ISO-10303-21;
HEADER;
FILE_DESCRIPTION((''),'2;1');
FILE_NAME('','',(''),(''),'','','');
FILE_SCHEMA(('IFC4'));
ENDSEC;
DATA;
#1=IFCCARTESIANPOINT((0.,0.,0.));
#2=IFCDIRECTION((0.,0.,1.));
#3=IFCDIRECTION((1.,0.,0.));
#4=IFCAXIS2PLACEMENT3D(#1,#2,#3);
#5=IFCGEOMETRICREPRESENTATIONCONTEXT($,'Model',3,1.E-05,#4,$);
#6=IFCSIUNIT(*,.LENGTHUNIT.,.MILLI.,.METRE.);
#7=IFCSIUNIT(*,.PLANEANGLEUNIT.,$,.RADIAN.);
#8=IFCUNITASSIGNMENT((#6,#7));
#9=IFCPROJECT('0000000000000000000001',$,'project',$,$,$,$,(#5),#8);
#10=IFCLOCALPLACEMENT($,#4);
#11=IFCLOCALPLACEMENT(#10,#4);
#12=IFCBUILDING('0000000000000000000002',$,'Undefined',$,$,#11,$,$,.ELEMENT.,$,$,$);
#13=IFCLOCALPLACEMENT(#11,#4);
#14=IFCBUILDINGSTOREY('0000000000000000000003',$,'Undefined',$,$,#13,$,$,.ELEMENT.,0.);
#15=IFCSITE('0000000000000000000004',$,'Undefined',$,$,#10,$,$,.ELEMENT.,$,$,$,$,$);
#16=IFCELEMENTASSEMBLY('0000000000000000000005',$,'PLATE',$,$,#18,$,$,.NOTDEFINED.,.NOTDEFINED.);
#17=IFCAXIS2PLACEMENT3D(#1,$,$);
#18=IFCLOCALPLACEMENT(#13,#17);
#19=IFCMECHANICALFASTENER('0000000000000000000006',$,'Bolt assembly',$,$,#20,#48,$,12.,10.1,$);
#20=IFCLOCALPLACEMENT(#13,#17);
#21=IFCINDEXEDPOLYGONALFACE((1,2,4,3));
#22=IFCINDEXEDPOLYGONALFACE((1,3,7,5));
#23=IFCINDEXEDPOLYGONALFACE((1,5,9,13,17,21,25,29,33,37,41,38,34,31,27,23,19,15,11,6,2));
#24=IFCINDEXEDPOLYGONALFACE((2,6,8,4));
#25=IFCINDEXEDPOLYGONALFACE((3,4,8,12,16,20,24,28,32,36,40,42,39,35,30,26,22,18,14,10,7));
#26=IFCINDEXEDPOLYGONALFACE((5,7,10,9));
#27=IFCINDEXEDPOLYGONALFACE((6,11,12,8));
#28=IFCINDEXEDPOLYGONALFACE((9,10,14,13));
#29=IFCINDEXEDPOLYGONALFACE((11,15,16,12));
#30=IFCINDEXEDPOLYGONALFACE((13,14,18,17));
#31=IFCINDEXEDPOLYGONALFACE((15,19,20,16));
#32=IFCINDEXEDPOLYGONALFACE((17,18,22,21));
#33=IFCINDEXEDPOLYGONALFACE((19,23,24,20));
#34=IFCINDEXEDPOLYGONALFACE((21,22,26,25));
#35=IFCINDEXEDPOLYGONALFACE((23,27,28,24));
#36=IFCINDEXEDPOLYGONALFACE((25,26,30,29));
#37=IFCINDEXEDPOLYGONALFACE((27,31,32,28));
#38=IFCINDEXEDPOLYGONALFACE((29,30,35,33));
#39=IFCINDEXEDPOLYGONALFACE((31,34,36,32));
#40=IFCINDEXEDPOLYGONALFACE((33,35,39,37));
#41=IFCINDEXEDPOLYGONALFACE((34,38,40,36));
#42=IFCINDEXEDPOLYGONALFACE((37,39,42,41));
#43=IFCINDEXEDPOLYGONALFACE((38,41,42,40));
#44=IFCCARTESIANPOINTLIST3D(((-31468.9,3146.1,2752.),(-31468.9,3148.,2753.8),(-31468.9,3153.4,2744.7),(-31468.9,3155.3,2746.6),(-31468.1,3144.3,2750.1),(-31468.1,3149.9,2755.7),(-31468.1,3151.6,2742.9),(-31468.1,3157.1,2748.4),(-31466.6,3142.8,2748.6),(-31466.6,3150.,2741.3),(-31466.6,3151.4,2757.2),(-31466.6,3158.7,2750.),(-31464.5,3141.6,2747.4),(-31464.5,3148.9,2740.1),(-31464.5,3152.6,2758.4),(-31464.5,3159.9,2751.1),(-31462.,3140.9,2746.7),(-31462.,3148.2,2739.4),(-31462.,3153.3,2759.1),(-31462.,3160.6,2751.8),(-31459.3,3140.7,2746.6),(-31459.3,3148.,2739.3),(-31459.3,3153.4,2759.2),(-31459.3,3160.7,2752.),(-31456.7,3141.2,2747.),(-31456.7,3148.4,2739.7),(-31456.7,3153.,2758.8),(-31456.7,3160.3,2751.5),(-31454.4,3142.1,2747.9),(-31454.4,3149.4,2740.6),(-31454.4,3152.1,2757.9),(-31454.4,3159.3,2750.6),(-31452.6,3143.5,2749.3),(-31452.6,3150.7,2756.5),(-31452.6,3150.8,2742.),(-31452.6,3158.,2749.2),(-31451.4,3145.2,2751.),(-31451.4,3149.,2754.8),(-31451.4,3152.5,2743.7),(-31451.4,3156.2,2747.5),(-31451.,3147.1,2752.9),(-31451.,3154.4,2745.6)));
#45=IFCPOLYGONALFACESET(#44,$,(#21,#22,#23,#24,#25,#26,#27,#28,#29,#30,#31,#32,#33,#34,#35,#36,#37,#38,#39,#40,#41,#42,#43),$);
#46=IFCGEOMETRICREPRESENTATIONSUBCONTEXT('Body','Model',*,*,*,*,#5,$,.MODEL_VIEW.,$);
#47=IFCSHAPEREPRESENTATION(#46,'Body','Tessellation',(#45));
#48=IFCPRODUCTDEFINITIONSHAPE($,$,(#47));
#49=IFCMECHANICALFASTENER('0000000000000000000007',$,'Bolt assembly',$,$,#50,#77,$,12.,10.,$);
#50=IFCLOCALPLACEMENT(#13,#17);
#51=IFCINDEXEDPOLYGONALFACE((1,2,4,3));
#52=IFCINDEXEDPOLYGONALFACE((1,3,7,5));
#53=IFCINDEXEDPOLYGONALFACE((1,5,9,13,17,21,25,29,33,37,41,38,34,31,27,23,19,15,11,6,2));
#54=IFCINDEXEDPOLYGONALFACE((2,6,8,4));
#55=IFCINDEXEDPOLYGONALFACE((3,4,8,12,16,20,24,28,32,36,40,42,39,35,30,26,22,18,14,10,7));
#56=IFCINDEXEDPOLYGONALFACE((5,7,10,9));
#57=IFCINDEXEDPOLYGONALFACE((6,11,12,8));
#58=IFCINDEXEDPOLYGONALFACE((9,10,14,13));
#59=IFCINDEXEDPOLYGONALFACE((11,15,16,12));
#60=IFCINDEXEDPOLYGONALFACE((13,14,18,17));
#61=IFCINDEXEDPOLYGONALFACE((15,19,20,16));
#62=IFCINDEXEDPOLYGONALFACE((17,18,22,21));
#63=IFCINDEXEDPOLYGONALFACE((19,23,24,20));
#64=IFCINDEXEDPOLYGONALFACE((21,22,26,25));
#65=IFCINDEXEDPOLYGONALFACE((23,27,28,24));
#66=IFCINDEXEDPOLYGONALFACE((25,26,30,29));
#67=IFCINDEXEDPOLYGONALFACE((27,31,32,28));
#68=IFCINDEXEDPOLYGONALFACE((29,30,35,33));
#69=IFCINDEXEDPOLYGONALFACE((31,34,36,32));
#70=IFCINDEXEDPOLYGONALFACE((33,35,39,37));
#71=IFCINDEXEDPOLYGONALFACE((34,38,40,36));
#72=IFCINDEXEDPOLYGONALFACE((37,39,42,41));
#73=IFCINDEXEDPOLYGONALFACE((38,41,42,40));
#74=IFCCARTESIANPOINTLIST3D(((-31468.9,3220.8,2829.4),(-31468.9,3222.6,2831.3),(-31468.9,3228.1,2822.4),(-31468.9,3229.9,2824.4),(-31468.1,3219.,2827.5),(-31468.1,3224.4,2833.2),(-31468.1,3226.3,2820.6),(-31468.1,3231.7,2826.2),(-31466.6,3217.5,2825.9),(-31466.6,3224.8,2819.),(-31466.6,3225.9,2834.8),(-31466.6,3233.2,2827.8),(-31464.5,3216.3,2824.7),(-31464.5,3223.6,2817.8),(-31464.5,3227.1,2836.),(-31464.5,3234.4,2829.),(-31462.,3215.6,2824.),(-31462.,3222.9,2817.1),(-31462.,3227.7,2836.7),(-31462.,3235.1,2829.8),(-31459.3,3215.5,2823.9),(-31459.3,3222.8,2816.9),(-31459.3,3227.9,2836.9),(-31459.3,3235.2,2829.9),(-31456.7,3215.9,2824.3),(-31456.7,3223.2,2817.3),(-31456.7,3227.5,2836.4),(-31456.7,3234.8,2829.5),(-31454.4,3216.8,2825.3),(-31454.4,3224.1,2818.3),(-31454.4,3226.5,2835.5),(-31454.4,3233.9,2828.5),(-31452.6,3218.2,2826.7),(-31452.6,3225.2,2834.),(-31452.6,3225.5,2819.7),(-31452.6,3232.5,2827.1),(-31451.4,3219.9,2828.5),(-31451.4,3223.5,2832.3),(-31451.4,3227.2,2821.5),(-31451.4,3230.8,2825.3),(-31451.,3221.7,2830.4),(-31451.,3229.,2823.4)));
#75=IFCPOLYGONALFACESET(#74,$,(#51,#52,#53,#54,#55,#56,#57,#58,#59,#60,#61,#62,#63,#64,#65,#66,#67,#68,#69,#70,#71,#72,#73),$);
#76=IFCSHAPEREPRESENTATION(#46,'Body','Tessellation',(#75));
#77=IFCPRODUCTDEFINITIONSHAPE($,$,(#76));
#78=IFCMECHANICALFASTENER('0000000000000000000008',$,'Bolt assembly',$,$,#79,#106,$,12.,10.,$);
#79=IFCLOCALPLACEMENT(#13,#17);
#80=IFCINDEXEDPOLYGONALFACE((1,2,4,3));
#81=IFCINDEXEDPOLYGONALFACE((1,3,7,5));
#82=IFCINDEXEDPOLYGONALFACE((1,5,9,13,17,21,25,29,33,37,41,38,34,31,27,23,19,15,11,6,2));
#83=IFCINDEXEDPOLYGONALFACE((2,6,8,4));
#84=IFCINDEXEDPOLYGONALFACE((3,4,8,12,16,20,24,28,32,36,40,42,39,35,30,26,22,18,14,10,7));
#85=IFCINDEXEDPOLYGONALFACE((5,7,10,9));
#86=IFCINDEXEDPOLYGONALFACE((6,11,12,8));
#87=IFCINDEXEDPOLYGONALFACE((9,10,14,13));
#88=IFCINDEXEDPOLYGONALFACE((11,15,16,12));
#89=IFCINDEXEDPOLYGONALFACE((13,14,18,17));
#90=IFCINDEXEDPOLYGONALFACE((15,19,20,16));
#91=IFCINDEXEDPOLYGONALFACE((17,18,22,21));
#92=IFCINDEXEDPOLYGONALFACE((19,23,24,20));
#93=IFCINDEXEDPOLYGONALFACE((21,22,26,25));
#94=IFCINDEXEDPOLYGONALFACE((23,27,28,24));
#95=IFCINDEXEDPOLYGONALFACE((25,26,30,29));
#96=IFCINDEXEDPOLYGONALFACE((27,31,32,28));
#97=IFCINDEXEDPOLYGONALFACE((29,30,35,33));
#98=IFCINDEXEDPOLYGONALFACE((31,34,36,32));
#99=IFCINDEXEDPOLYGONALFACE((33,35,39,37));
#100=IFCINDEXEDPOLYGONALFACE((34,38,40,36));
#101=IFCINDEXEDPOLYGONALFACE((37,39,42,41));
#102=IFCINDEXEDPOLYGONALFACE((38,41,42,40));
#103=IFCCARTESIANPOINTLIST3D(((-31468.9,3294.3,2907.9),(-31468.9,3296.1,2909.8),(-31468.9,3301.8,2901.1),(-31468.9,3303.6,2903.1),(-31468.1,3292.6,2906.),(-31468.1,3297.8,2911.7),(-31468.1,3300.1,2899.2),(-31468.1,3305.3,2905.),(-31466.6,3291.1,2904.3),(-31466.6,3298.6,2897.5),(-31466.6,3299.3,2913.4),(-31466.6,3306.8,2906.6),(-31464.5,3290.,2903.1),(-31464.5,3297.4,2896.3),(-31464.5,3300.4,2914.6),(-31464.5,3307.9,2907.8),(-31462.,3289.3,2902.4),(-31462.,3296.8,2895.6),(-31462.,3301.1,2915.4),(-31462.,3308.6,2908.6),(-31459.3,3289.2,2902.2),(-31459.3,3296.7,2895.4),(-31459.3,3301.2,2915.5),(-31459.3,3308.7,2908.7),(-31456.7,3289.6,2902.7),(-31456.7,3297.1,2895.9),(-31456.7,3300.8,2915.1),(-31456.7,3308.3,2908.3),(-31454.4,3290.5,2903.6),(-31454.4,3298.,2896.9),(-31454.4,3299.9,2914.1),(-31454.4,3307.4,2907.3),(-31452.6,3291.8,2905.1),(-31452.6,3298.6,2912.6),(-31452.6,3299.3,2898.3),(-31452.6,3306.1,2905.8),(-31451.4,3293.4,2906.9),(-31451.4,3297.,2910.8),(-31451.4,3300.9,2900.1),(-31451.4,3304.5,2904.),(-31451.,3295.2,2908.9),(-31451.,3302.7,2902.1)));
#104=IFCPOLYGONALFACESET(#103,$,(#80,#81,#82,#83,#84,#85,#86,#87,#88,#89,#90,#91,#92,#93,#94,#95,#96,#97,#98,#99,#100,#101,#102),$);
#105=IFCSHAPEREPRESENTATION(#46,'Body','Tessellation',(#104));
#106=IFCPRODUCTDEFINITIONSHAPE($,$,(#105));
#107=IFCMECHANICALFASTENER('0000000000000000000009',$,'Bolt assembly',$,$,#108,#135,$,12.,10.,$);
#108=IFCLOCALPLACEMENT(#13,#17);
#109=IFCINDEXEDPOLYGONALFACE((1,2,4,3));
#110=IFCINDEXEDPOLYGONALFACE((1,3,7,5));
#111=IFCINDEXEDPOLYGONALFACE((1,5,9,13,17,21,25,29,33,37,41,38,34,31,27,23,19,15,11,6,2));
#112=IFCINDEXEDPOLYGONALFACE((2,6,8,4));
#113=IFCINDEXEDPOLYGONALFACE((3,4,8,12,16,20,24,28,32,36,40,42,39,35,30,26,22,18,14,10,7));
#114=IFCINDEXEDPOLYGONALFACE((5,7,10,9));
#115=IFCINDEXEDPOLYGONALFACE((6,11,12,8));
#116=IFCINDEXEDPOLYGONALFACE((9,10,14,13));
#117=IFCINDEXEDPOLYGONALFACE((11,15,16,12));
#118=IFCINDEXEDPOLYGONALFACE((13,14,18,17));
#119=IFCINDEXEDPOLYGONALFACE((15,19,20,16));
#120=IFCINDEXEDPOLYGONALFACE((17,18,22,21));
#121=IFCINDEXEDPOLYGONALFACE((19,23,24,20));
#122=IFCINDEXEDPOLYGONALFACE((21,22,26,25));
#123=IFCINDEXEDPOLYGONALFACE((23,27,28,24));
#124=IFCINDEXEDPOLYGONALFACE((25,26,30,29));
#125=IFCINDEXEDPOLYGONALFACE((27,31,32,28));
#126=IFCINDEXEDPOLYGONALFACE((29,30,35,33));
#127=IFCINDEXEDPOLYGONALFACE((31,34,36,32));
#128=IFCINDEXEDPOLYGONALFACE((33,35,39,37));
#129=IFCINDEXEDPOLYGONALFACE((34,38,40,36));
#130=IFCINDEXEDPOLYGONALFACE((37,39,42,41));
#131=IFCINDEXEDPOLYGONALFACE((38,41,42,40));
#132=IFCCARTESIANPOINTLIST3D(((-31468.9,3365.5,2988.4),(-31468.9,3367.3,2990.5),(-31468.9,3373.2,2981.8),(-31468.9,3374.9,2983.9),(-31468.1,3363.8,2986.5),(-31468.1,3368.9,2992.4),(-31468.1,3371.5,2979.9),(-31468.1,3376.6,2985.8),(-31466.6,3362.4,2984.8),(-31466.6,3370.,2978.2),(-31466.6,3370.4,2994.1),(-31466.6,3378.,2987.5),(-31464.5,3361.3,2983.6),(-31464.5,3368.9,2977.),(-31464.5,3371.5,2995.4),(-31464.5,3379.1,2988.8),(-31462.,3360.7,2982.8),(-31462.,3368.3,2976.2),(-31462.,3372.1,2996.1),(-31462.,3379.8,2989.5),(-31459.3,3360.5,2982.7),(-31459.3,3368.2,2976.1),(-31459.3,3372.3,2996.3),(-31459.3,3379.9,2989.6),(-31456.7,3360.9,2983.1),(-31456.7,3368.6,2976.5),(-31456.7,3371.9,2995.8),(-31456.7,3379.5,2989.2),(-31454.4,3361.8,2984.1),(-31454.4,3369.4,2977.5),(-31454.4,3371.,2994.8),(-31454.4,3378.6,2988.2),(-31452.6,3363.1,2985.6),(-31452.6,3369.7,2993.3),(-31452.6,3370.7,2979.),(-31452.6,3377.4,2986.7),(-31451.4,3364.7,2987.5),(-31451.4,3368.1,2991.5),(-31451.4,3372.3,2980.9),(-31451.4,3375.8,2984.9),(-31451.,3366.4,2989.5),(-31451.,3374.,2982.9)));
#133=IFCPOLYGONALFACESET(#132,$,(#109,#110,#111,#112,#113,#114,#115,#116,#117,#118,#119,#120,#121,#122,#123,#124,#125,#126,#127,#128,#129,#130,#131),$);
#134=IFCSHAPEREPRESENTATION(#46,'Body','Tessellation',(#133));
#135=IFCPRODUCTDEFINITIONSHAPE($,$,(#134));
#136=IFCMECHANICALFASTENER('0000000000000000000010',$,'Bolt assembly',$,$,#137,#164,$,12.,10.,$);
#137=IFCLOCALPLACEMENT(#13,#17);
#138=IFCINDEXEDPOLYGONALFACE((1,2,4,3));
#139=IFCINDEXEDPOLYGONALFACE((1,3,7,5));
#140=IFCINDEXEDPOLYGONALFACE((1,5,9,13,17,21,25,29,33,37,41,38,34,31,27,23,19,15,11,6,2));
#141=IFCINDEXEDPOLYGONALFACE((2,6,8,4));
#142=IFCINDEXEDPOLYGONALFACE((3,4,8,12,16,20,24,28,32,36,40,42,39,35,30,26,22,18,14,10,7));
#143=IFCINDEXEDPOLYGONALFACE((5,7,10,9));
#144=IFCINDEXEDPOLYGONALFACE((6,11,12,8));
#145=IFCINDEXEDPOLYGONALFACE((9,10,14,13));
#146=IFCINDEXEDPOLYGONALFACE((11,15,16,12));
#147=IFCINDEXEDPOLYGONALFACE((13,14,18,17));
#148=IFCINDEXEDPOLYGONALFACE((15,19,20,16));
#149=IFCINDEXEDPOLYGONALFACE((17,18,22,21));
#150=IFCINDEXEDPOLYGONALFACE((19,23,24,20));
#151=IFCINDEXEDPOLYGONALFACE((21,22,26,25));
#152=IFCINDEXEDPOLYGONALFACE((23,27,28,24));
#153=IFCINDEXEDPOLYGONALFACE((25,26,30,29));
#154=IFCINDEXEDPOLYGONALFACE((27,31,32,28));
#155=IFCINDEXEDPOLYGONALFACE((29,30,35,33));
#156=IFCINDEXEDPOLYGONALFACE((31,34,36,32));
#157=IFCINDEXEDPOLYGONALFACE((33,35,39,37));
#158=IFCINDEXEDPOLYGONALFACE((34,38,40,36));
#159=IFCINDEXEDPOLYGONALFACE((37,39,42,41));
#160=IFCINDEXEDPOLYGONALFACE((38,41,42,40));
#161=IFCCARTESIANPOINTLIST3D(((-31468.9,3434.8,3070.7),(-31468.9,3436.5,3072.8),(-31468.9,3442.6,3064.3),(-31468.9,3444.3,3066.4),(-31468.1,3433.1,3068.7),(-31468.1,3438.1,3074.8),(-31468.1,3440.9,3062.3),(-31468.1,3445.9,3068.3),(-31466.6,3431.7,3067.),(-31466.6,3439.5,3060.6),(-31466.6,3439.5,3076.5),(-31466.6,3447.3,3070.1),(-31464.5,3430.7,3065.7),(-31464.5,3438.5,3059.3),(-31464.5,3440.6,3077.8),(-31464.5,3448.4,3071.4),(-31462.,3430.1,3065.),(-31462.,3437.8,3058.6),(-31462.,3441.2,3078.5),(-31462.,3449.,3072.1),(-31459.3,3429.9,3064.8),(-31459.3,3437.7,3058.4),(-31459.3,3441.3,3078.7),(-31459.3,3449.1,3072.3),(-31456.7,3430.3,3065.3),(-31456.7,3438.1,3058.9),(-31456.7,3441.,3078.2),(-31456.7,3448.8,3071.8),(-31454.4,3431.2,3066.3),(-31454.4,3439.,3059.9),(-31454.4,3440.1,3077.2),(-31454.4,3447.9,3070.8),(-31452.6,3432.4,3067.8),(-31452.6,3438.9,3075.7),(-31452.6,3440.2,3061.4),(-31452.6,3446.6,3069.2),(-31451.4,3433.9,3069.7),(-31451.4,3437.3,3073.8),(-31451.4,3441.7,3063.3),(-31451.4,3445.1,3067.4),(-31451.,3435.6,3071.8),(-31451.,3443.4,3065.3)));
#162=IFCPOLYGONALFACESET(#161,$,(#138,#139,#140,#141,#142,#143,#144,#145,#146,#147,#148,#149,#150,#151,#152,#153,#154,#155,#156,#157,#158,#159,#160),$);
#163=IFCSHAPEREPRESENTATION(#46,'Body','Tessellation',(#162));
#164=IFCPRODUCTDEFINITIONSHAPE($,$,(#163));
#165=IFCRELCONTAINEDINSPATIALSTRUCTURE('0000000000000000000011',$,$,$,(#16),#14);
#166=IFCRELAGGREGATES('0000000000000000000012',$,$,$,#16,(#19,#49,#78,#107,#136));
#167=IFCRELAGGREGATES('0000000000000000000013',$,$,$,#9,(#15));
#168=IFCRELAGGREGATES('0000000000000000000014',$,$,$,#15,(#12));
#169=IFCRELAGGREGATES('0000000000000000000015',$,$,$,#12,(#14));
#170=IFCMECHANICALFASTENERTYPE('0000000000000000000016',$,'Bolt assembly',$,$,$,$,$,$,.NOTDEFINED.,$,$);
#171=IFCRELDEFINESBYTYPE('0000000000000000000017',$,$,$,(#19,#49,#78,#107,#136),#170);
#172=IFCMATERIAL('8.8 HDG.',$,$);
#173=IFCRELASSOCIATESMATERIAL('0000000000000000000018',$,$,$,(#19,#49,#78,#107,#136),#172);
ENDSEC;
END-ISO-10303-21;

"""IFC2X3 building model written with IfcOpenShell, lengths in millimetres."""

from ifc_helpers import new_model, si_unit, frame, origin_with_axes, origin_2d_with_axis, place, context, subcontext, project, spatial, circle, extrude, source, transform, mapped, material, type_object, element, aggregate, save


model = new_model("IFC2X3")

# Units and contexts
model_context = context("Model", 3, precision=1e-05, world=origin_with_axes())
body_context = subcontext(model_context, "Body", "Model", "MODEL_VIEW")
ifc_project = project(units=[si_unit("LENGTHUNIT", "METRE", prefix="MILLI"), si_unit("PLANEANGLEUNIT", "RADIAN")], contexts=[model_context])

# Site, building, storey
site_placement = place(None, origin_with_axes())
site = spatial("IfcSite", under=ifc_project, at=site_placement, Name="Undefined", CompositionType="ELEMENT")
building_placement = place(site_placement, origin_with_axes())
building = spatial("IfcBuilding", under=site, at=building_placement, Name="Undefined", CompositionType="ELEMENT")
storey_placement = place(building_placement, origin_with_axes())
storey = spatial("IfcBuildingStorey", under=building, at=storey_placement, Name="Undefined", CompositionType="ELEMENT", Elevation=0.0)

# Element assembly, mechanical fasteners
assembly_placement = place(storey_placement, origin_with_axes())
assembly = element("IfcElementAssembly", 1, at=assembly_placement, inside=storey, Name="PLATE", AssemblyPlace="NOTDEFINED", PredefinedType="NOTDEFINED")
ifc_material_1 = material(Name="8.8 HDG.")
mechanical_fastener_type = type_object("IfcMechanicalFastenerType", Name="Bolt assembly")
shared_shape_1 = source(origin_with_axes(), body_context, "Body", "SweptSolid", [
    extrude(circle(Radius=9.0, at=origin_2d_with_axis()), frame((0.0, 0.0, 0.0), z_axis=(0.0, 1.0, 0.0), x_axis=(1.0, 0.0, 0.0)), (0.0, 0.0, 1.0), 10.3),
])
mechanical_fastener_1_placement = place(assembly_placement, frame((-31460.0, 3154.4, 2745.6), z_axis=(0.000001, -0.707107, -0.707107), x_axis=(1.0, 0.000001, 0.000001)))
mechanical_fastener_1 = element("IfcMechanicalFastener", 2, at=mechanical_fastener_1_placement, type_object=mechanical_fastener_type, material=ifc_material_1, Name="Bolt assembly", NominalDiameter=12.0, NominalLength=10.1, context=body_context, shape_type="MappedRepresentation", body=[
    mapped(shared_shape_1, transform((0.0, 0.0, 0.0))),
])
shared_shape_2 = source(origin_with_axes(), body_context, "Body", "SweptSolid", [
    extrude(circle(Radius=9.0, at=origin_2d_with_axis()), frame((0.0, 0.9, 0.0), z_axis=(0.0, 1.0, 0.0), x_axis=(1.0, 0.0, 0.0)), (0.0, 0.0, 1.0), 10.1),
])
mechanical_fastener_2_placement = place(assembly_placement, frame((-31460.0, 3229.7, 2822.8), z_axis=(0.000001, -0.689814, -0.723987), x_axis=(1.0, 0.000001, 0.000001)))
mechanical_fastener_2 = element("IfcMechanicalFastener", 3, at=mechanical_fastener_2_placement, type_object=mechanical_fastener_type, material=ifc_material_1, Name="Bolt assembly", NominalDiameter=12.0, NominalLength=10.0, context=body_context, shape_type="MappedRepresentation", body=[
    mapped(shared_shape_2, transform((0.0, 0.0, 0.0))),
])
shared_shape_3 = source(origin_with_axes(), body_context, "Body", "SweptSolid", [
    extrude(circle(Radius=9.0, at=origin_2d_with_axis()), frame((0.0, 0.5, 0.0), z_axis=(0.0, 1.0, 0.0), x_axis=(1.0, 0.0, 0.0)), (0.0, 0.0, 1.0), 10.1),
])
mechanical_fastener_3_placement = place(assembly_placement, frame((-31460.0, 3303.1, 2901.7), z_axis=(0.000001, -0.672118, -0.740444), x_axis=(1.0, 0.000001, 0.000001)))
mechanical_fastener_3 = element("IfcMechanicalFastener", 4, at=mechanical_fastener_3_placement, type_object=mechanical_fastener_type, material=ifc_material_1, Name="Bolt assembly", NominalDiameter=12.0, NominalLength=10.0, context=body_context, shape_type="MappedRepresentation", body=[
    mapped(shared_shape_3, transform((0.0, 0.0, 0.0))),
])
shared_shape_4 = source(origin_with_axes(), body_context, "Body", "SweptSolid", [
    extrude(circle(Radius=9.0, at=origin_2d_with_axis()), frame((0.0, 0.7, 0.0), z_axis=(0.0, 1.0, 0.0), x_axis=(1.0, 0.0, 0.0)), (0.0, 0.0, 1.0), 10.1),
])
mechanical_fastener_4_placement = place(assembly_placement, frame((-31460.0, 3374.6, 2982.4), z_axis=(0.000001, -0.65403, -0.756468), x_axis=(1.0, 0.000001, 0.000001)))
mechanical_fastener_4 = element("IfcMechanicalFastener", 5, at=mechanical_fastener_4_placement, type_object=mechanical_fastener_type, material=ifc_material_1, Name="Bolt assembly", NominalDiameter=12.0, NominalLength=10.0, context=body_context, shape_type="MappedRepresentation", body=[
    mapped(shared_shape_4, transform((0.0, 0.0, 0.0))),
])
shared_shape_5 = source(origin_with_axes(), body_context, "Body", "SweptSolid", [
    extrude(circle(Radius=9.0, at=origin_2d_with_axis()), frame((0.0, 0.8, 0.0), z_axis=(0.0, 1.0, 0.0), x_axis=(1.0, 0.0, 0.0)), (0.0, 0.0, 1.0), 10.1),
])
mechanical_fastener_5_placement = place(assembly_placement, frame((-31460.0, 3444.1, 3064.8), z_axis=(0.000001, -0.63556, -0.772051), x_axis=(1.0, 0.000001, 0.000001)))
mechanical_fastener_5 = element("IfcMechanicalFastener", 6, at=mechanical_fastener_5_placement, type_object=mechanical_fastener_type, material=ifc_material_1, Name="Bolt assembly", NominalDiameter=12.0, NominalLength=10.0, context=body_context, shape_type="MappedRepresentation", body=[
    mapped(shared_shape_5, transform((0.0, 0.0, 0.0))),
])
aggregate(assembly, [mechanical_fastener_1, mechanical_fastener_2, mechanical_fastener_3, mechanical_fastener_4, mechanical_fastener_5])

save(model, "model.ifc")
